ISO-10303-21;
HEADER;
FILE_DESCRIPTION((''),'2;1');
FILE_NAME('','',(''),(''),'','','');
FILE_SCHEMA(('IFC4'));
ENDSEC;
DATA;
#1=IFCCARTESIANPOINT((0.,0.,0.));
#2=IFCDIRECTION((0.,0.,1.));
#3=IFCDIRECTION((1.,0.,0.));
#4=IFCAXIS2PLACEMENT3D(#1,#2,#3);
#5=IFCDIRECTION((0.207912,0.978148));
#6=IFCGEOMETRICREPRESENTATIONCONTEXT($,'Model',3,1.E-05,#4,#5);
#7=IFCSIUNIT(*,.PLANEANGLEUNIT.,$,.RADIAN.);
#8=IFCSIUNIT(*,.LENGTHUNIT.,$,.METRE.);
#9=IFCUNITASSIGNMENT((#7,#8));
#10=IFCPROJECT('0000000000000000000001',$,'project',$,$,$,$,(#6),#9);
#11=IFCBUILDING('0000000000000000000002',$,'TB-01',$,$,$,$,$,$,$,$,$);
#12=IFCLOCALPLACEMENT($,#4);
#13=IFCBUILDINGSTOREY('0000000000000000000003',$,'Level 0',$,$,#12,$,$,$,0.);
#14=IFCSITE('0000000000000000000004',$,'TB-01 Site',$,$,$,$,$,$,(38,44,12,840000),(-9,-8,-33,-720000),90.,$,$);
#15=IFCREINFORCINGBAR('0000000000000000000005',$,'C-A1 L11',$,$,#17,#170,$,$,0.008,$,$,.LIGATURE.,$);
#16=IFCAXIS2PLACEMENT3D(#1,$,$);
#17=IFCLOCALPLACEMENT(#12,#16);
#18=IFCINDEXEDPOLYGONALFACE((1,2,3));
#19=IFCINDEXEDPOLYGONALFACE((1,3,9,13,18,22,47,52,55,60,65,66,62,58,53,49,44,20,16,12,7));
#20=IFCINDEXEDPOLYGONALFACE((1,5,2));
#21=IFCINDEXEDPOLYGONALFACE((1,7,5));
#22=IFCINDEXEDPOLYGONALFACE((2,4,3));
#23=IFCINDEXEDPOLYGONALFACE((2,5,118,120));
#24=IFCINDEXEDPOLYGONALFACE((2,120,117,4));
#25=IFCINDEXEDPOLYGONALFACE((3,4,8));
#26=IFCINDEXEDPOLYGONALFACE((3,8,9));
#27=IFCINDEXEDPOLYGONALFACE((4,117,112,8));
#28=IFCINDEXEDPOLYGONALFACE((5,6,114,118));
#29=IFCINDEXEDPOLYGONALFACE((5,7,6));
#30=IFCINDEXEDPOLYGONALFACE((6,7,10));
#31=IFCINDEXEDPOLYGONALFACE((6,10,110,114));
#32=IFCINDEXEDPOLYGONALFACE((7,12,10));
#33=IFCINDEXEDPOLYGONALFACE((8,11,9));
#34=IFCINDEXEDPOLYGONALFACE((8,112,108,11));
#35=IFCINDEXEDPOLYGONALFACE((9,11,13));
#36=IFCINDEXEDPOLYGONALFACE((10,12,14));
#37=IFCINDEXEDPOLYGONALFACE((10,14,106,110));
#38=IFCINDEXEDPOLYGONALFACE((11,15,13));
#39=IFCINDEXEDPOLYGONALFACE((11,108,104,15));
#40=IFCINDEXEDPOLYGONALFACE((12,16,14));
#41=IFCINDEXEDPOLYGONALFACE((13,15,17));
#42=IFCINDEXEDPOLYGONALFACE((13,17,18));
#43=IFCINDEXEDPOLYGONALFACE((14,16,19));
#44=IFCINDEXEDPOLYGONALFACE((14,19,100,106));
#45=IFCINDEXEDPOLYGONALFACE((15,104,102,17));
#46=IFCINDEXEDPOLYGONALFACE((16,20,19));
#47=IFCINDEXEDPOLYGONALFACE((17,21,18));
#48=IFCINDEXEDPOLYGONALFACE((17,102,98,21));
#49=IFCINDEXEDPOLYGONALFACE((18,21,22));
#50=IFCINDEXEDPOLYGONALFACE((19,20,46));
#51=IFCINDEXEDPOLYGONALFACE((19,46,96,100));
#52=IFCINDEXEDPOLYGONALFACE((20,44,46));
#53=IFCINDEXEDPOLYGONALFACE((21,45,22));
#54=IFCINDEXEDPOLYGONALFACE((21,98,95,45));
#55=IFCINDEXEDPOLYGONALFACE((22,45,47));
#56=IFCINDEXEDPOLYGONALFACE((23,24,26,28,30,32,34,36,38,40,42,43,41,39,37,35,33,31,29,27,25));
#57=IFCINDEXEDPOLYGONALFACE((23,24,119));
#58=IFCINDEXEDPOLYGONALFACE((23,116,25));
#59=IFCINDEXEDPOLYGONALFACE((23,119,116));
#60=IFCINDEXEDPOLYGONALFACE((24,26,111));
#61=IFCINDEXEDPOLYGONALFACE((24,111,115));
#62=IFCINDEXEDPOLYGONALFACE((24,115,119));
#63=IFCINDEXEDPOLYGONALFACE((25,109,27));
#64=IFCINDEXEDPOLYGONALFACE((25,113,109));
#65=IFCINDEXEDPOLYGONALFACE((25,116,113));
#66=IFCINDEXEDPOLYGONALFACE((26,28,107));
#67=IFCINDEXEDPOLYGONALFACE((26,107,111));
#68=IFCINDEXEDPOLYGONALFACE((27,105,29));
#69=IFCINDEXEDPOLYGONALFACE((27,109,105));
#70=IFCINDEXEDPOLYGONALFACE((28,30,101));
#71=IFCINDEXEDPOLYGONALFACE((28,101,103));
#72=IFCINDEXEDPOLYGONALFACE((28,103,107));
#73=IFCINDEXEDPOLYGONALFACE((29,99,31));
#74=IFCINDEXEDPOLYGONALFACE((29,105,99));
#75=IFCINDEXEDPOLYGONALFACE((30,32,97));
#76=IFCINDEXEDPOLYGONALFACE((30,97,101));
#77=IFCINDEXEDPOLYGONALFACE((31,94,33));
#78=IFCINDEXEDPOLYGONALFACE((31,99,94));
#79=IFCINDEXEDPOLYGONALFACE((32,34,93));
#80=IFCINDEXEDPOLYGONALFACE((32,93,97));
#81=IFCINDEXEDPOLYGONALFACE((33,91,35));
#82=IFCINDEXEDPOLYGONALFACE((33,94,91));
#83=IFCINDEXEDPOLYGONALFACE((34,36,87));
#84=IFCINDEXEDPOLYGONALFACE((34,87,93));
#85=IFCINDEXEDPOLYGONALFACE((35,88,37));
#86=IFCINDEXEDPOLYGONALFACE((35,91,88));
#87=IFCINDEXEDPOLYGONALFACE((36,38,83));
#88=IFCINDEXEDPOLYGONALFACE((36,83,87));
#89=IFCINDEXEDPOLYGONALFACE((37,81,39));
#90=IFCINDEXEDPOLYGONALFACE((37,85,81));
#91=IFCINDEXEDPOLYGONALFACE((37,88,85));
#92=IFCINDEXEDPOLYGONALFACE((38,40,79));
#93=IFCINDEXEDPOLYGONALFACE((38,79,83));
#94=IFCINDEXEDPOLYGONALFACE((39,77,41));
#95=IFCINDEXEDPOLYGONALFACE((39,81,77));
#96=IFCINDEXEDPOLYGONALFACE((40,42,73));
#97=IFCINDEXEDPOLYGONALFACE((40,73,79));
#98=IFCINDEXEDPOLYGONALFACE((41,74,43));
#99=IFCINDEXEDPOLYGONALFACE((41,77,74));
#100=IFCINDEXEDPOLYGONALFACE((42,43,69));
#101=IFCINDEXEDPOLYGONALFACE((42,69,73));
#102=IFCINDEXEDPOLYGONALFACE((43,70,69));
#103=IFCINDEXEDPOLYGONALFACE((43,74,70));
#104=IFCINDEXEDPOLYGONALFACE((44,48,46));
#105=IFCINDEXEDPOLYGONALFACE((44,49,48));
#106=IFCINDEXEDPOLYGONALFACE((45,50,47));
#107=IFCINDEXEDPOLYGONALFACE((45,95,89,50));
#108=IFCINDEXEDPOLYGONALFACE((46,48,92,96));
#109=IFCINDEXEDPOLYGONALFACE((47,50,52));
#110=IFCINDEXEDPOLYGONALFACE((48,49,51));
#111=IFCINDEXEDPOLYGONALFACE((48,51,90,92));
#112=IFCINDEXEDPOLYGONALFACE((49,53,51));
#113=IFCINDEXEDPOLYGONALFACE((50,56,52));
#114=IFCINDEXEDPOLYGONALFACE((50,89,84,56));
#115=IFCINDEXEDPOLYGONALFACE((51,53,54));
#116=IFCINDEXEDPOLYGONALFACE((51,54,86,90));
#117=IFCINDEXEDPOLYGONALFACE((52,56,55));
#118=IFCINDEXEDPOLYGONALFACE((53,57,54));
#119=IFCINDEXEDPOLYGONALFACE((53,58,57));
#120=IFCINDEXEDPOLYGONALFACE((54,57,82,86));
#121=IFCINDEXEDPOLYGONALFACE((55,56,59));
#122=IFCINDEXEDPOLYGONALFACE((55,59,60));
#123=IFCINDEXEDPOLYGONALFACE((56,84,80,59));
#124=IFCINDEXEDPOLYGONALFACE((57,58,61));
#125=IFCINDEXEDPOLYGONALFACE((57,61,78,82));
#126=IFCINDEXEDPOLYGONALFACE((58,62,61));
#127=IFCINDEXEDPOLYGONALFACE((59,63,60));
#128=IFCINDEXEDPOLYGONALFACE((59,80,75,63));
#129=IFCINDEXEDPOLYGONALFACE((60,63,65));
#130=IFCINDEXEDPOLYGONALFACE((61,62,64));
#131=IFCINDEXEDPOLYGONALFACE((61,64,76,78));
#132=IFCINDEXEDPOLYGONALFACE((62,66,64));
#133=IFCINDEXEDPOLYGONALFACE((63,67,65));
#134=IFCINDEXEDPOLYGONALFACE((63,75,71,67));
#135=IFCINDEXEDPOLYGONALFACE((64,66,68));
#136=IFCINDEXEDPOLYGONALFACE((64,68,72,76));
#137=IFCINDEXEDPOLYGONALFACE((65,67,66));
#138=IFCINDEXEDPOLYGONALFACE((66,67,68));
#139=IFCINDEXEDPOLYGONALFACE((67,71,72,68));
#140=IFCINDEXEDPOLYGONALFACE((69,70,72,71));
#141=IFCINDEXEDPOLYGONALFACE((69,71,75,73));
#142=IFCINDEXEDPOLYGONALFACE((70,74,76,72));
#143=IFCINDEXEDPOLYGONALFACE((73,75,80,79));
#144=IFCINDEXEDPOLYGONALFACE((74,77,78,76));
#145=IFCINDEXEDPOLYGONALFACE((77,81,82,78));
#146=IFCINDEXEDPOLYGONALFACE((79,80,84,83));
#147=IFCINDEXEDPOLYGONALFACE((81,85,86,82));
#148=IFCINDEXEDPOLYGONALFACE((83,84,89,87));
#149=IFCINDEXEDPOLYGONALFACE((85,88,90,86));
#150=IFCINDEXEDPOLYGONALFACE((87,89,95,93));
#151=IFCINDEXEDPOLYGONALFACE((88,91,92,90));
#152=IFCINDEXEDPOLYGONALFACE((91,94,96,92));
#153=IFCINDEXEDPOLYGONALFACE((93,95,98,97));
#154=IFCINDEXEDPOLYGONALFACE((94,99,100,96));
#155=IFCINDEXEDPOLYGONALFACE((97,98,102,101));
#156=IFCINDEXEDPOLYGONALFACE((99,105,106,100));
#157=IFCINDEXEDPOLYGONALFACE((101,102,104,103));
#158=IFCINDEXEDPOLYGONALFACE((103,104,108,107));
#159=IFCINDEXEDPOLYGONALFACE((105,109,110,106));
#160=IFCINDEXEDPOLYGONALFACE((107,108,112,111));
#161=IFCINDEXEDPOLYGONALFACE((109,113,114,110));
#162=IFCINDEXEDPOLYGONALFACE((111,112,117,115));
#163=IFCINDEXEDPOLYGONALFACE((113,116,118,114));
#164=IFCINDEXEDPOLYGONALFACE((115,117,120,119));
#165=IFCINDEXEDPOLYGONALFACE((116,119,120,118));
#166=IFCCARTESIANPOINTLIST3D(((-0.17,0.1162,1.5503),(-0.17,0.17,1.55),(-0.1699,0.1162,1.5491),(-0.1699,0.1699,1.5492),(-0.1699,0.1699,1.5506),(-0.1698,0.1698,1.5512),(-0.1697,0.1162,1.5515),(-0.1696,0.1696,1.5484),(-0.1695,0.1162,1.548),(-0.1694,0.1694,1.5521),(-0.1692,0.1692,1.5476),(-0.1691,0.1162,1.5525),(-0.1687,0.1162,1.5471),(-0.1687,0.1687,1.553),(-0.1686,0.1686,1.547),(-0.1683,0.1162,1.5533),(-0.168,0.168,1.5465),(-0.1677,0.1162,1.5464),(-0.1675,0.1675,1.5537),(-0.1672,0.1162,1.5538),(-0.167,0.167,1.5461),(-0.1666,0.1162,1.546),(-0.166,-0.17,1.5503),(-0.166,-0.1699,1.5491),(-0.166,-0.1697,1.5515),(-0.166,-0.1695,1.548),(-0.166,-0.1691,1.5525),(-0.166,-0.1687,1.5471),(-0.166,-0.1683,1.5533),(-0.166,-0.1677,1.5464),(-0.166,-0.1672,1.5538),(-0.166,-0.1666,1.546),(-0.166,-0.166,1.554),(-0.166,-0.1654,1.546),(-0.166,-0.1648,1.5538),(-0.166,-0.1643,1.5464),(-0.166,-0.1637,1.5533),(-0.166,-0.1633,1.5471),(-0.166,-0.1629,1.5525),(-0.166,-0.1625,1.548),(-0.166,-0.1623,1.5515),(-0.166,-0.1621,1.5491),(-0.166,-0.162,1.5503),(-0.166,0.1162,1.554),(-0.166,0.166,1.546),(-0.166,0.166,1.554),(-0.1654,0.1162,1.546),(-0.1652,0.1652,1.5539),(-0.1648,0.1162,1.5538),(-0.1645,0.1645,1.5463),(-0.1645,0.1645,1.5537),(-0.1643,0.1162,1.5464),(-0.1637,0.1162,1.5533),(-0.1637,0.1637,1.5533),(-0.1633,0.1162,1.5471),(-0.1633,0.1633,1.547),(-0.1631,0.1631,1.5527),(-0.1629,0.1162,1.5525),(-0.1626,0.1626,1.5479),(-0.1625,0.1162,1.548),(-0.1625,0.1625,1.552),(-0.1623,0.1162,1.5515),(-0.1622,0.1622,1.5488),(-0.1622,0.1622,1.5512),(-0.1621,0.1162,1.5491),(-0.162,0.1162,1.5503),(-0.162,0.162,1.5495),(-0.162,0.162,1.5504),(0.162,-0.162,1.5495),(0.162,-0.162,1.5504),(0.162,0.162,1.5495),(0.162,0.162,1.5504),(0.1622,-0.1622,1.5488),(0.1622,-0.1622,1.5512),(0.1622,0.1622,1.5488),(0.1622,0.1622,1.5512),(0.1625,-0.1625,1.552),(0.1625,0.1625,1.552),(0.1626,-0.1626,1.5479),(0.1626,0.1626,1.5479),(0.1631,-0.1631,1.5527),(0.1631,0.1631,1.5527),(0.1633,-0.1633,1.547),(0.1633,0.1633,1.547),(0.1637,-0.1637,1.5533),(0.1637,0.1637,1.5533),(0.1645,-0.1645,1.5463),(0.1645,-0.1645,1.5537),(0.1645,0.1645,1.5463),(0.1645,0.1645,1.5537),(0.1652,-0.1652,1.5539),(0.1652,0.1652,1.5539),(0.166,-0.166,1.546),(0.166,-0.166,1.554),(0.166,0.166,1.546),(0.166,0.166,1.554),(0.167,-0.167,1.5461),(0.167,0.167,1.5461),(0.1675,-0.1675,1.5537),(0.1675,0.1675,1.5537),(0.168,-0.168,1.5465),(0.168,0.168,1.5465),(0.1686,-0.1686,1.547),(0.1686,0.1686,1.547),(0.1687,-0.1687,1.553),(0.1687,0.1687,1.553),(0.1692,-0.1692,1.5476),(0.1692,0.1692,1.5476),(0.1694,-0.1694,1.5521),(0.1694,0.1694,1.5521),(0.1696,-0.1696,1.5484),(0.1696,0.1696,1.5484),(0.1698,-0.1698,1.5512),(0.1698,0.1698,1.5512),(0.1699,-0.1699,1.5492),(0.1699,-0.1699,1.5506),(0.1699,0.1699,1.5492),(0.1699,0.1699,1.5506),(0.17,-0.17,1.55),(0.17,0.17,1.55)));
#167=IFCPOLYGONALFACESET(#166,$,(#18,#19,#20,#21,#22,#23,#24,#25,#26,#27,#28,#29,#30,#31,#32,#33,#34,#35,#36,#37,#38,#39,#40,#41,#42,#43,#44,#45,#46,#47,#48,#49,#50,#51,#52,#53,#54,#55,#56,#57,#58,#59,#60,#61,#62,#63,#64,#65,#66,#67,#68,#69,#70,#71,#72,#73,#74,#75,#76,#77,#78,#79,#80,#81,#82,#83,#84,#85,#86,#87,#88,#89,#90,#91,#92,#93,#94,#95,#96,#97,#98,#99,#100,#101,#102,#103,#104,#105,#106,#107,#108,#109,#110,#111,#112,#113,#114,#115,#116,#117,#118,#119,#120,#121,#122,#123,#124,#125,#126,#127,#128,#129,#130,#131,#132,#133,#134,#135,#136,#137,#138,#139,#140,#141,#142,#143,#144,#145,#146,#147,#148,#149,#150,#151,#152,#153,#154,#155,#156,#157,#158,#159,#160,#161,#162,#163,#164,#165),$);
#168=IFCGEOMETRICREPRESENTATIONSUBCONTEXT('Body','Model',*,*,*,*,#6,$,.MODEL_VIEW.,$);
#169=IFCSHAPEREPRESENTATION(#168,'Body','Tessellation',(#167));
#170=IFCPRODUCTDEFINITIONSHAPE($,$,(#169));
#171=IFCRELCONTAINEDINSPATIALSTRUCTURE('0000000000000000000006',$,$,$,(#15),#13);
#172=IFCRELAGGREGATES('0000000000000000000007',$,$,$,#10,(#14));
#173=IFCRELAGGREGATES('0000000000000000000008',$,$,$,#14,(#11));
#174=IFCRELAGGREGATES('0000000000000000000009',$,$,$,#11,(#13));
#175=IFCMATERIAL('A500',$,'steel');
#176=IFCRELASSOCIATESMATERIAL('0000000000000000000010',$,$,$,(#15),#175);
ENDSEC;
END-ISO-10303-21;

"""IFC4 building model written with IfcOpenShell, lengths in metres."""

from ifc_helpers import new_model, entity, si_unit, direction, origin_with_axes, place, context, subcontext, project, spatial, material, element, save


model = new_model("IFC4")

# Units and contexts
model_context = context("Model", 3, precision=1e-05, world=origin_with_axes(), true_north=direction((0.207912, 0.978148)))
body_context = subcontext(model_context, "Body", "Model", "MODEL_VIEW")
ifc_project = project(units=[si_unit("PLANEANGLEUNIT", "RADIAN"), si_unit("LENGTHUNIT", "METRE")], contexts=[model_context])

# Site, building, storey
site = spatial("IfcSite", under=ifc_project, Name="TB-01 Site", RefLatitude=(38, 44, 12, 840000), RefLongitude=(-9, -8, -33, -720000), RefElevation=90.0)
building = spatial("IfcBuilding", under=site, Name="TB-01")
storey_placement = place(None, origin_with_axes())
storey = spatial("IfcBuildingStorey", under=building, at=storey_placement, Name="Level 0", Elevation=0.0)

# Reinforcing bar
ifc_material_1 = material(Name="A500", Category="steel")
reinforcing_bar_1_placement = place(storey_placement, origin_with_axes())
element("IfcReinforcingBar", 1, at=reinforcing_bar_1_placement, inside=storey, material=ifc_material_1, Name="C-A1 L11", NominalDiameter=0.008, PredefinedType="LIGATURE", context=body_context, shape_type="AdvancedSweptSolid", body=[
    entity("IfcSweptDiskSolid", entity("IfcPolyline", [entity("IfcCartesianPoint", [-0.166, -0.166, 1.55]), entity("IfcCartesianPoint", [0.166, -0.166, 1.55]), entity("IfcCartesianPoint", [0.166, 0.166, 1.55]), entity("IfcCartesianPoint", [-0.166, 0.166, 1.55]), entity("IfcCartesianPoint", [-0.166, 0.1162, 1.55])]), 0.004),
])

save(model, "model.ifc")
